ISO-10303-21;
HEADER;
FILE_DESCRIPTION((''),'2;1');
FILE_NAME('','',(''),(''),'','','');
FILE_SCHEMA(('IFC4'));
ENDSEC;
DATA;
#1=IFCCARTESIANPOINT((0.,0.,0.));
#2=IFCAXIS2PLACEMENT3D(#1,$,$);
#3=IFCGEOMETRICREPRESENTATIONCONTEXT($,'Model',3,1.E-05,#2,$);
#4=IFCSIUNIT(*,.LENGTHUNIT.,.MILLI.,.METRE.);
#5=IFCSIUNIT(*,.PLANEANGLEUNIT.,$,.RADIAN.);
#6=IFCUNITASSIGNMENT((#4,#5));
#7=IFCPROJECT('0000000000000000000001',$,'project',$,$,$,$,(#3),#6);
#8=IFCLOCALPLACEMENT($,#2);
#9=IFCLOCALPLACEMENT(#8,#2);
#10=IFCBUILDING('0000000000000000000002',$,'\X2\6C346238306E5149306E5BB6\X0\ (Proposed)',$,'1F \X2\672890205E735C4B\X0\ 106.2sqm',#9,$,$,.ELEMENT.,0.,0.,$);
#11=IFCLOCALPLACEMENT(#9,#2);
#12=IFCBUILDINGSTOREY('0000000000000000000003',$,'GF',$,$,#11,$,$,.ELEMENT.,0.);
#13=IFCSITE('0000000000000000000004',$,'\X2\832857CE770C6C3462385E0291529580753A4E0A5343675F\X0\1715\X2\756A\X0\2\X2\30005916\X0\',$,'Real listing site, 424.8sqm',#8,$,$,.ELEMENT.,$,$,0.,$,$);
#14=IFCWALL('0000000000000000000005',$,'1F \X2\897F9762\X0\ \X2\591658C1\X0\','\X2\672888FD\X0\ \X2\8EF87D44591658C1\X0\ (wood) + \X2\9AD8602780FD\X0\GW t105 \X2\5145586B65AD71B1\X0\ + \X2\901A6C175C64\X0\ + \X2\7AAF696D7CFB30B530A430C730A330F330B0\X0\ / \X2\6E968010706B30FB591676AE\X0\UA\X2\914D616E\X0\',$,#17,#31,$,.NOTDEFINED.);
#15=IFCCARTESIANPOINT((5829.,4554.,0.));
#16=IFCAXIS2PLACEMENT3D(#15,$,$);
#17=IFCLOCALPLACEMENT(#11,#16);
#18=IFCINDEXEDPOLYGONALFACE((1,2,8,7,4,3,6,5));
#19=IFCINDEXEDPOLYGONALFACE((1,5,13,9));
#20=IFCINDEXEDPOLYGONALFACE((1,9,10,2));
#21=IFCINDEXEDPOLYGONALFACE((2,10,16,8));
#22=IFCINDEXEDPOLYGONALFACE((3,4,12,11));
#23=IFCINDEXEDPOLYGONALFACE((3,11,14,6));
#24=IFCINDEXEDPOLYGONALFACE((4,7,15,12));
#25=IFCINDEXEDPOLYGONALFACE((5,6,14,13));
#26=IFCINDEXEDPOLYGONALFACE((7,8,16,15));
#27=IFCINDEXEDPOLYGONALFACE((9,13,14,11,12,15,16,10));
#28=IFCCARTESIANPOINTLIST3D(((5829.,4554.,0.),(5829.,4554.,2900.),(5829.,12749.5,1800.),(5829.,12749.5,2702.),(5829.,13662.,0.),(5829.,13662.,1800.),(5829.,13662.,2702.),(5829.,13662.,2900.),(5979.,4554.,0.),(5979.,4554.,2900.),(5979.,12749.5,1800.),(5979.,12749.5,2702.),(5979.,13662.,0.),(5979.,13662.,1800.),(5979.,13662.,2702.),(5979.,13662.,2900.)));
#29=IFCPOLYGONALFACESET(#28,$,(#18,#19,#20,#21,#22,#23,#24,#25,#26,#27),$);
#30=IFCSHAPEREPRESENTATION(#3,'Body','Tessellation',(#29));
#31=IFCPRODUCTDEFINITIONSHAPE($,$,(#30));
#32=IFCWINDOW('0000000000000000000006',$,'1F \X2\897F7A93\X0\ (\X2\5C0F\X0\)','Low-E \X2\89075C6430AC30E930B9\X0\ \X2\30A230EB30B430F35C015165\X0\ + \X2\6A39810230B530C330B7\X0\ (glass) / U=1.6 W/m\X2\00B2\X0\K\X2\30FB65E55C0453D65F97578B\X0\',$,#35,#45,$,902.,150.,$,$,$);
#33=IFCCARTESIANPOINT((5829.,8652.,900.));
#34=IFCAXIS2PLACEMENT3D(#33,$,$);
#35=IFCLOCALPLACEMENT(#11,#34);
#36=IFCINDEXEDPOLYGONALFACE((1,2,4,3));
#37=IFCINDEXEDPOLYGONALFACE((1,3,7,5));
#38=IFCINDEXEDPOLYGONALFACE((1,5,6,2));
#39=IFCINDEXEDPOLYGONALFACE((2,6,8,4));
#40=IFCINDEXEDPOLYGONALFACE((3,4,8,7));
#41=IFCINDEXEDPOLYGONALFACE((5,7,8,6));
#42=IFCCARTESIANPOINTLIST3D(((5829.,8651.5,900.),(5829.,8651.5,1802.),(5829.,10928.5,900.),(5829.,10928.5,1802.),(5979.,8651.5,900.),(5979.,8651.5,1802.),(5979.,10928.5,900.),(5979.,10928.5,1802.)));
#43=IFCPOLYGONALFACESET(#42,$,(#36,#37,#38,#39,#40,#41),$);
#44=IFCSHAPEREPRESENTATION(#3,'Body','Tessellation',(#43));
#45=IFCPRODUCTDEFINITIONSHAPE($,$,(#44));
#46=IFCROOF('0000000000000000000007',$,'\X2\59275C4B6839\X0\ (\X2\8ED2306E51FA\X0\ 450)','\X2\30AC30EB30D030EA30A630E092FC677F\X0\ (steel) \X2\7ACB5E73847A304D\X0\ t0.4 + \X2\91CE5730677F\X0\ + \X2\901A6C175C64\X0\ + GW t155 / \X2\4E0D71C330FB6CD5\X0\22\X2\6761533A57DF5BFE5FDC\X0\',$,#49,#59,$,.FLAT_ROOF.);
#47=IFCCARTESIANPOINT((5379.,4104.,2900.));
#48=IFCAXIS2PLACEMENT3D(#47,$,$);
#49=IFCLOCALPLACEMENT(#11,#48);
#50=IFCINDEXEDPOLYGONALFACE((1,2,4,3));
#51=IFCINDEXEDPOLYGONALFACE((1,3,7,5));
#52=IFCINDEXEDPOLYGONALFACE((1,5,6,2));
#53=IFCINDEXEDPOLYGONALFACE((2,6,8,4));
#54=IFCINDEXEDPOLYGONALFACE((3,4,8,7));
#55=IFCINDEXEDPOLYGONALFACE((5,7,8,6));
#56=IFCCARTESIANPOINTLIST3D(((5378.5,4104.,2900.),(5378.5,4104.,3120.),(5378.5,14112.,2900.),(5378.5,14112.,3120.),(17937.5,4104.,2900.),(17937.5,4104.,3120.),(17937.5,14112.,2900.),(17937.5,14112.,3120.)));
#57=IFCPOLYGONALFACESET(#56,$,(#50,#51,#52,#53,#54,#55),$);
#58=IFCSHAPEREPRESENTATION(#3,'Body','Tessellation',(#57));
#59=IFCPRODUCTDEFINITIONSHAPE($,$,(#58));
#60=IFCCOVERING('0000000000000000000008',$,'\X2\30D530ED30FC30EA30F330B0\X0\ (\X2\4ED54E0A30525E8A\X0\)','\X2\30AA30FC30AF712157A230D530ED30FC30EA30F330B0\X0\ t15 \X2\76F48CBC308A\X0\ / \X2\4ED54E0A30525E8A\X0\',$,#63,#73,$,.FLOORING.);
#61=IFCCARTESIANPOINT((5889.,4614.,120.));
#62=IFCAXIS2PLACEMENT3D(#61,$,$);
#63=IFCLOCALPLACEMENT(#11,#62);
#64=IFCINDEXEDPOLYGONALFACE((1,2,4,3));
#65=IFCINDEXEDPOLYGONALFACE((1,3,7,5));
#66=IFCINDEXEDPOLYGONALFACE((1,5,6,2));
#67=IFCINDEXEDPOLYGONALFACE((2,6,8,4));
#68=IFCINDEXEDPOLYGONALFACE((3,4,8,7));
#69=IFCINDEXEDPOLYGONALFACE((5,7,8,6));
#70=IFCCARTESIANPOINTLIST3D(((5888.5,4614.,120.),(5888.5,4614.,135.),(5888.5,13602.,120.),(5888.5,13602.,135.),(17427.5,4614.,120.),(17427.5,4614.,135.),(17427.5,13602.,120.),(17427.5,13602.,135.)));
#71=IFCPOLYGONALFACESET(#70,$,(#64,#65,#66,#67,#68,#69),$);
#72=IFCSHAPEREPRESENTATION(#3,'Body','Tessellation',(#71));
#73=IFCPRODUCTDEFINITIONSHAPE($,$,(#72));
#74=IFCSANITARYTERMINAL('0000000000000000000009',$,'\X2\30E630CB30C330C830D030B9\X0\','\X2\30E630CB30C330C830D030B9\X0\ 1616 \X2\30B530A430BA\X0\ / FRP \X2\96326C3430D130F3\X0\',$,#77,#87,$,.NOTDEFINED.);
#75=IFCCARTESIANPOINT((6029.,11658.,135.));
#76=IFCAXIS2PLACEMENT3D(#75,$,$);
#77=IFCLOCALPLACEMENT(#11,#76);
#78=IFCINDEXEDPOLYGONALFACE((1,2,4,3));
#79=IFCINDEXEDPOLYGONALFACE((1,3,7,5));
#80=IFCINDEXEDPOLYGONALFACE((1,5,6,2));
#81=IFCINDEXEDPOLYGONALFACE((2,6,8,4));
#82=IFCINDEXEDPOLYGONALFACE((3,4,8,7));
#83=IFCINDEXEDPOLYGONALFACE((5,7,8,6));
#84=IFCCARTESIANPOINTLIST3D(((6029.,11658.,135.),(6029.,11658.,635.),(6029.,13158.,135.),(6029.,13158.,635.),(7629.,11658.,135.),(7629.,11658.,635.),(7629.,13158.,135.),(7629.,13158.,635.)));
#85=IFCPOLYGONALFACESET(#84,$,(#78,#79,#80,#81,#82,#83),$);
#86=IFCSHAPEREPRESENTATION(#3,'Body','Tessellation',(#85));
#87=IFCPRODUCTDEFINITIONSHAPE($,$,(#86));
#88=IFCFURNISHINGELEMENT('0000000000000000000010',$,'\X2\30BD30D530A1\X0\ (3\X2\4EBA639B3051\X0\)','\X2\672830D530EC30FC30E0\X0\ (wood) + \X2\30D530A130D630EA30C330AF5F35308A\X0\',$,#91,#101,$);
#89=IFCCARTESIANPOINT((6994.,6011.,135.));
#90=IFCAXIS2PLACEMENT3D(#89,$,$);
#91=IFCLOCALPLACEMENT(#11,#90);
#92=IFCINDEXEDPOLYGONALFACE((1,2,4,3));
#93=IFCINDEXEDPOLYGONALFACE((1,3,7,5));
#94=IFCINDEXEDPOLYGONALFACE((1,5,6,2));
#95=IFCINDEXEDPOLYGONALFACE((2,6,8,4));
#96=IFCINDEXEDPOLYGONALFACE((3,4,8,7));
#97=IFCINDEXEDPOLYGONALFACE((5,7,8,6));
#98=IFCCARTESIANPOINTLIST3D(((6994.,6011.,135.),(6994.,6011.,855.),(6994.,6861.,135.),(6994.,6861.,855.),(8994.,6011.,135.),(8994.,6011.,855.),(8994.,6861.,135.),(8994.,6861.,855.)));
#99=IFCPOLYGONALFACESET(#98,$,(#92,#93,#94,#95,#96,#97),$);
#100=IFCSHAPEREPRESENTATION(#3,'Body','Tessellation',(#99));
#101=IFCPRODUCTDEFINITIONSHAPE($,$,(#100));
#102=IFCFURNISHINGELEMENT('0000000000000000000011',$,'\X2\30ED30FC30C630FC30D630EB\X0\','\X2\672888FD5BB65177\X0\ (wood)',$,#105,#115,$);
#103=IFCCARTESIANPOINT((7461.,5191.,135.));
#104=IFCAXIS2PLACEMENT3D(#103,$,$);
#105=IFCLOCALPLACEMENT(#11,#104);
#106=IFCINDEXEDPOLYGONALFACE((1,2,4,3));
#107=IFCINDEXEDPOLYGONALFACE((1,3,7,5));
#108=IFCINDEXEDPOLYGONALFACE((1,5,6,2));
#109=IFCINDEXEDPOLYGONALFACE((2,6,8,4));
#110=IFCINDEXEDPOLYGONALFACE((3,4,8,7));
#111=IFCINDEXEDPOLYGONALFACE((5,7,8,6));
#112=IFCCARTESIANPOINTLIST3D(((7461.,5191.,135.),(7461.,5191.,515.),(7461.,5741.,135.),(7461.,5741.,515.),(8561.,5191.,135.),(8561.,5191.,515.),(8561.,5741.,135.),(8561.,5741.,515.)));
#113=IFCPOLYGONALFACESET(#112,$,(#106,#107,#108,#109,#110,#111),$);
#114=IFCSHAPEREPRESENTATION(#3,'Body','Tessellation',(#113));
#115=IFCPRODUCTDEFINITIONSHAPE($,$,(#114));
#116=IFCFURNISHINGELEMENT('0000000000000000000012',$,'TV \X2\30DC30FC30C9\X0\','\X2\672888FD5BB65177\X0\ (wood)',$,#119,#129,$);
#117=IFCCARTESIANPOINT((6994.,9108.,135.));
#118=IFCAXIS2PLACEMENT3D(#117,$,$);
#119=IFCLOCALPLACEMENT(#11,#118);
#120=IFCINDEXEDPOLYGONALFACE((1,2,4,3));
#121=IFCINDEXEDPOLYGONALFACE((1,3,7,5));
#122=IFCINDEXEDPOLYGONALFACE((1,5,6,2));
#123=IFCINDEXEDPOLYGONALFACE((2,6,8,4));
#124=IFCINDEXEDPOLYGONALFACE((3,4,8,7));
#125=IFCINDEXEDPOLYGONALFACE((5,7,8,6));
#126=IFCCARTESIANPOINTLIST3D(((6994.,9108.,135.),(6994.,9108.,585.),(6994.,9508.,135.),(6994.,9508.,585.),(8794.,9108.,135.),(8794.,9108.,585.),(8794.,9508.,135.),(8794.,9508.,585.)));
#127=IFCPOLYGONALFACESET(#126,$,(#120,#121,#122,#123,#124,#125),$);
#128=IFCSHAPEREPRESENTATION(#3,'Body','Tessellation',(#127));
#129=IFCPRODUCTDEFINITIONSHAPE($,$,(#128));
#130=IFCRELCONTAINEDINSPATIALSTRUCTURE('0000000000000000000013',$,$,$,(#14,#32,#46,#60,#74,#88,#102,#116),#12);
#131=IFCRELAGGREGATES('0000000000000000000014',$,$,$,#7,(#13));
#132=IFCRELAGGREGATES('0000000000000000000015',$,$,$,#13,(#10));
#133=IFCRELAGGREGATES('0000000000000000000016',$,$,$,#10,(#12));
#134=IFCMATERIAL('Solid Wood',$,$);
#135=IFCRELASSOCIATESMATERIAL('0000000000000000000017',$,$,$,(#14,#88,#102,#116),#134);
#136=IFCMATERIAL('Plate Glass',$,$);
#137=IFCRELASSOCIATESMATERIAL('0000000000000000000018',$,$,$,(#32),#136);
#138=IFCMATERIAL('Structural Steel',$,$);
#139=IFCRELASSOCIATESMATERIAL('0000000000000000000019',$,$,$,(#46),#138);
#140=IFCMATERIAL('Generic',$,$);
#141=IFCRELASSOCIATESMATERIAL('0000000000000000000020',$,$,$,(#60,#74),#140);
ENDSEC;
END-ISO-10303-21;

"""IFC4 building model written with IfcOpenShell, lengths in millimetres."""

from ifc_helpers import new_model, si_unit, frame, frame_2d, origin, place, context, project, spatial, rectangle, extrude, material, element, fill, save


model = new_model("IFC4")

# Units and contexts
model_context = context("Model", 3, precision=1e-05, world=origin())
ifc_project = project(units=[si_unit("LENGTHUNIT", "METRE", prefix="MILLI"), si_unit("PLANEANGLEUNIT", "RADIAN")], contexts=[model_context])

# Site, building, storey
site_placement = place(None, origin())
site = spatial("IfcSite", under=ifc_project, at=site_placement, Name="茨城県水戸市酒門町上千束1715番2　外", ObjectType="Real listing site, 424.8sqm", CompositionType="ELEMENT", RefElevation=0.0)
building_placement = place(site_placement, origin())
building = spatial("IfcBuilding", under=site, at=building_placement, Name="水戸の光の家 (Proposed)", ObjectType="1F 木造平屋 106.2sqm", CompositionType="ELEMENT", ElevationOfRefHeight=0.0, ElevationOfTerrain=0.0)
storey_placement = place(building_placement, origin())
storey = spatial("IfcBuildingStorey", under=building, at=storey_placement, Name="GF", CompositionType="ELEMENT", Elevation=0.0)

# Shared definitions
ifc_material_1 = material(Name="Solid Wood")

# Shared definitions
ifc_material_2 = material(Name="Plate Glass")

# Wall, opening, window
wall_1_placement = place(storey_placement, frame((5829.0, 4554.0, 0.0)))
wall_1 = element("IfcWall", 1, at=wall_1_placement, inside=storey, material=ifc_material_1, Name="1F 西面 外壁", Description="木製 軸組外壁 (wood) + 高性能GW t105 充填断熱 + 通気層 + 窯業系サイディング / 準耐火・外皮UA配慮", PredefinedType="NOTDEFINED", context=model_context, shape_type="SweptSolid", body=[
    extrude(rectangle(XDim=150.0, YDim=9108.0, at=frame_2d((75.0, 4554.0))), frame((5829.0, 4554.0, 0.0)), (0.0, 0.0, 1.0), 2900.0),
])
opening_1_placement = place(storey_placement, frame((5829.0, 8652.0, 900.0)))
opening_1 = element("IfcOpeningElement", 2, at=opening_1_placement, cuts=wall_1, PredefinedType="NOTDEFINED", context=model_context, shape_type="SweptSolid", body=[
    extrude(rectangle(XDim=150.0, YDim=2277.0, at=frame_2d((75.0, 1138.0))), frame((5829.0, 8652.0, 900.0)), (0.0, 0.0, 1.0), 902.0),
])
window_1_placement = place(storey_placement, frame((5829.0, 8652.0, 900.0)))
window_1 = element("IfcWindow", 3, at=window_1_placement, inside=storey, material=ifc_material_2, Name="1F 西窓 (小)", Description="Low-E 複層ガラス アルゴン封入 + 樹脂サッシ (glass) / U=1.6 W/m²K・日射取得型", OverallHeight=902.0, OverallWidth=150.0, context=model_context, shape_type="SweptSolid", body=[
    extrude(rectangle(XDim=150.0, YDim=2277.0, at=frame_2d((75.0, 1138.0))), frame((5829.0, 8652.0, 900.0)), (0.0, 0.0, 1.0), 902.0),
])
fill(opening_1, window_1)

# Roof
ifc_material_3 = material(Name="Structural Steel")
roof_placement = place(storey_placement, frame((5379.0, 4104.0, 2900.0)))
element("IfcRoof", 4, at=roof_placement, inside=storey, material=ifc_material_3, Name="大屋根 (軒の出 450)", Description="ガルバリウム鋼板 (steel) 立平葺き t0.4 + 野地板 + 通気層 + GW t155 / 不燃・法22条区域対応", PredefinedType="FLAT_ROOF", context=model_context, shape_type="SweptSolid", body=[
    extrude(rectangle(XDim=12559.0, YDim=10008.0, at=frame_2d((6279.0, 5004.0))), frame((5379.0, 4104.0, 2900.0)), (0.0, 0.0, 1.0), 220.0),
])

# Covering
ifc_material_4 = material(Name="Generic")
covering_placement = place(storey_placement, frame((5889.0, 4614.0, 120.0)))
element("IfcCovering", 5, at=covering_placement, inside=storey, material=ifc_material_4, Name="フローリング (仕上げ床)", Description="オーク無垢フローリング t15 直貼り / 仕上げ床", PredefinedType="FLOORING", context=model_context, shape_type="SweptSolid", body=[
    extrude(rectangle(XDim=11539.0, YDim=8988.0, at=frame_2d((5769.0, 4494.0))), frame((5889.0, 4614.0, 120.0)), (0.0, 0.0, 1.0), 15.0),
])

# Sanitary terminal
sanitary_terminal_placement = place(storey_placement, frame((6029.0, 11658.0, 135.0)))
element("IfcSanitaryTerminal", 6, at=sanitary_terminal_placement, inside=storey, material=ifc_material_4, Name="ユニットバス", Description="ユニットバス 1616 サイズ / FRP 防水パン", PredefinedType="NOTDEFINED", context=model_context, shape_type="SweptSolid", body=[
    extrude(rectangle(XDim=1600.0, YDim=1500.0, at=frame_2d((800.0, 750.0))), frame((6029.0, 11658.0, 135.0)), (0.0, 0.0, 1.0), 500.0),
])

# Furnishing elements
furnishing_1_placement = place(storey_placement, frame((6994.0, 6011.0, 135.0)))
element("IfcFurnishingElement", 7, at=furnishing_1_placement, inside=storey, material=ifc_material_1, Name="ソファ (3人掛け)", Description="木フレーム (wood) + ファブリック張り", context=model_context, shape_type="SweptSolid", body=[
    extrude(rectangle(XDim=2000.0, YDim=850.0, at=frame_2d((1000.0, 425.0))), frame((6994.0, 6011.0, 135.0)), (0.0, 0.0, 1.0), 720.0),
])
furnishing_2_placement = place(storey_placement, frame((7461.0, 5191.0, 135.0)))
element("IfcFurnishingElement", 8, at=furnishing_2_placement, inside=storey, material=ifc_material_1, Name="ローテーブル", Description="木製家具 (wood)", context=model_context, shape_type="SweptSolid", body=[
    extrude(rectangle(XDim=1100.0, YDim=550.0, at=frame_2d((550.0, 275.0))), frame((7461.0, 5191.0, 135.0)), (0.0, 0.0, 1.0), 380.0),
])
furnishing_3_placement = place(storey_placement, frame((6994.0, 9108.0, 135.0)))
element("IfcFurnishingElement", 9, at=furnishing_3_placement, inside=storey, material=ifc_material_1, Name="TV ボード", Description="木製家具 (wood)", context=model_context, shape_type="SweptSolid", body=[
    extrude(rectangle(XDim=1800.0, YDim=400.0, at=frame_2d((900.0, 200.0))), frame((6994.0, 9108.0, 135.0)), (0.0, 0.0, 1.0), 450.0),
])

save(model, "model.ifc")
